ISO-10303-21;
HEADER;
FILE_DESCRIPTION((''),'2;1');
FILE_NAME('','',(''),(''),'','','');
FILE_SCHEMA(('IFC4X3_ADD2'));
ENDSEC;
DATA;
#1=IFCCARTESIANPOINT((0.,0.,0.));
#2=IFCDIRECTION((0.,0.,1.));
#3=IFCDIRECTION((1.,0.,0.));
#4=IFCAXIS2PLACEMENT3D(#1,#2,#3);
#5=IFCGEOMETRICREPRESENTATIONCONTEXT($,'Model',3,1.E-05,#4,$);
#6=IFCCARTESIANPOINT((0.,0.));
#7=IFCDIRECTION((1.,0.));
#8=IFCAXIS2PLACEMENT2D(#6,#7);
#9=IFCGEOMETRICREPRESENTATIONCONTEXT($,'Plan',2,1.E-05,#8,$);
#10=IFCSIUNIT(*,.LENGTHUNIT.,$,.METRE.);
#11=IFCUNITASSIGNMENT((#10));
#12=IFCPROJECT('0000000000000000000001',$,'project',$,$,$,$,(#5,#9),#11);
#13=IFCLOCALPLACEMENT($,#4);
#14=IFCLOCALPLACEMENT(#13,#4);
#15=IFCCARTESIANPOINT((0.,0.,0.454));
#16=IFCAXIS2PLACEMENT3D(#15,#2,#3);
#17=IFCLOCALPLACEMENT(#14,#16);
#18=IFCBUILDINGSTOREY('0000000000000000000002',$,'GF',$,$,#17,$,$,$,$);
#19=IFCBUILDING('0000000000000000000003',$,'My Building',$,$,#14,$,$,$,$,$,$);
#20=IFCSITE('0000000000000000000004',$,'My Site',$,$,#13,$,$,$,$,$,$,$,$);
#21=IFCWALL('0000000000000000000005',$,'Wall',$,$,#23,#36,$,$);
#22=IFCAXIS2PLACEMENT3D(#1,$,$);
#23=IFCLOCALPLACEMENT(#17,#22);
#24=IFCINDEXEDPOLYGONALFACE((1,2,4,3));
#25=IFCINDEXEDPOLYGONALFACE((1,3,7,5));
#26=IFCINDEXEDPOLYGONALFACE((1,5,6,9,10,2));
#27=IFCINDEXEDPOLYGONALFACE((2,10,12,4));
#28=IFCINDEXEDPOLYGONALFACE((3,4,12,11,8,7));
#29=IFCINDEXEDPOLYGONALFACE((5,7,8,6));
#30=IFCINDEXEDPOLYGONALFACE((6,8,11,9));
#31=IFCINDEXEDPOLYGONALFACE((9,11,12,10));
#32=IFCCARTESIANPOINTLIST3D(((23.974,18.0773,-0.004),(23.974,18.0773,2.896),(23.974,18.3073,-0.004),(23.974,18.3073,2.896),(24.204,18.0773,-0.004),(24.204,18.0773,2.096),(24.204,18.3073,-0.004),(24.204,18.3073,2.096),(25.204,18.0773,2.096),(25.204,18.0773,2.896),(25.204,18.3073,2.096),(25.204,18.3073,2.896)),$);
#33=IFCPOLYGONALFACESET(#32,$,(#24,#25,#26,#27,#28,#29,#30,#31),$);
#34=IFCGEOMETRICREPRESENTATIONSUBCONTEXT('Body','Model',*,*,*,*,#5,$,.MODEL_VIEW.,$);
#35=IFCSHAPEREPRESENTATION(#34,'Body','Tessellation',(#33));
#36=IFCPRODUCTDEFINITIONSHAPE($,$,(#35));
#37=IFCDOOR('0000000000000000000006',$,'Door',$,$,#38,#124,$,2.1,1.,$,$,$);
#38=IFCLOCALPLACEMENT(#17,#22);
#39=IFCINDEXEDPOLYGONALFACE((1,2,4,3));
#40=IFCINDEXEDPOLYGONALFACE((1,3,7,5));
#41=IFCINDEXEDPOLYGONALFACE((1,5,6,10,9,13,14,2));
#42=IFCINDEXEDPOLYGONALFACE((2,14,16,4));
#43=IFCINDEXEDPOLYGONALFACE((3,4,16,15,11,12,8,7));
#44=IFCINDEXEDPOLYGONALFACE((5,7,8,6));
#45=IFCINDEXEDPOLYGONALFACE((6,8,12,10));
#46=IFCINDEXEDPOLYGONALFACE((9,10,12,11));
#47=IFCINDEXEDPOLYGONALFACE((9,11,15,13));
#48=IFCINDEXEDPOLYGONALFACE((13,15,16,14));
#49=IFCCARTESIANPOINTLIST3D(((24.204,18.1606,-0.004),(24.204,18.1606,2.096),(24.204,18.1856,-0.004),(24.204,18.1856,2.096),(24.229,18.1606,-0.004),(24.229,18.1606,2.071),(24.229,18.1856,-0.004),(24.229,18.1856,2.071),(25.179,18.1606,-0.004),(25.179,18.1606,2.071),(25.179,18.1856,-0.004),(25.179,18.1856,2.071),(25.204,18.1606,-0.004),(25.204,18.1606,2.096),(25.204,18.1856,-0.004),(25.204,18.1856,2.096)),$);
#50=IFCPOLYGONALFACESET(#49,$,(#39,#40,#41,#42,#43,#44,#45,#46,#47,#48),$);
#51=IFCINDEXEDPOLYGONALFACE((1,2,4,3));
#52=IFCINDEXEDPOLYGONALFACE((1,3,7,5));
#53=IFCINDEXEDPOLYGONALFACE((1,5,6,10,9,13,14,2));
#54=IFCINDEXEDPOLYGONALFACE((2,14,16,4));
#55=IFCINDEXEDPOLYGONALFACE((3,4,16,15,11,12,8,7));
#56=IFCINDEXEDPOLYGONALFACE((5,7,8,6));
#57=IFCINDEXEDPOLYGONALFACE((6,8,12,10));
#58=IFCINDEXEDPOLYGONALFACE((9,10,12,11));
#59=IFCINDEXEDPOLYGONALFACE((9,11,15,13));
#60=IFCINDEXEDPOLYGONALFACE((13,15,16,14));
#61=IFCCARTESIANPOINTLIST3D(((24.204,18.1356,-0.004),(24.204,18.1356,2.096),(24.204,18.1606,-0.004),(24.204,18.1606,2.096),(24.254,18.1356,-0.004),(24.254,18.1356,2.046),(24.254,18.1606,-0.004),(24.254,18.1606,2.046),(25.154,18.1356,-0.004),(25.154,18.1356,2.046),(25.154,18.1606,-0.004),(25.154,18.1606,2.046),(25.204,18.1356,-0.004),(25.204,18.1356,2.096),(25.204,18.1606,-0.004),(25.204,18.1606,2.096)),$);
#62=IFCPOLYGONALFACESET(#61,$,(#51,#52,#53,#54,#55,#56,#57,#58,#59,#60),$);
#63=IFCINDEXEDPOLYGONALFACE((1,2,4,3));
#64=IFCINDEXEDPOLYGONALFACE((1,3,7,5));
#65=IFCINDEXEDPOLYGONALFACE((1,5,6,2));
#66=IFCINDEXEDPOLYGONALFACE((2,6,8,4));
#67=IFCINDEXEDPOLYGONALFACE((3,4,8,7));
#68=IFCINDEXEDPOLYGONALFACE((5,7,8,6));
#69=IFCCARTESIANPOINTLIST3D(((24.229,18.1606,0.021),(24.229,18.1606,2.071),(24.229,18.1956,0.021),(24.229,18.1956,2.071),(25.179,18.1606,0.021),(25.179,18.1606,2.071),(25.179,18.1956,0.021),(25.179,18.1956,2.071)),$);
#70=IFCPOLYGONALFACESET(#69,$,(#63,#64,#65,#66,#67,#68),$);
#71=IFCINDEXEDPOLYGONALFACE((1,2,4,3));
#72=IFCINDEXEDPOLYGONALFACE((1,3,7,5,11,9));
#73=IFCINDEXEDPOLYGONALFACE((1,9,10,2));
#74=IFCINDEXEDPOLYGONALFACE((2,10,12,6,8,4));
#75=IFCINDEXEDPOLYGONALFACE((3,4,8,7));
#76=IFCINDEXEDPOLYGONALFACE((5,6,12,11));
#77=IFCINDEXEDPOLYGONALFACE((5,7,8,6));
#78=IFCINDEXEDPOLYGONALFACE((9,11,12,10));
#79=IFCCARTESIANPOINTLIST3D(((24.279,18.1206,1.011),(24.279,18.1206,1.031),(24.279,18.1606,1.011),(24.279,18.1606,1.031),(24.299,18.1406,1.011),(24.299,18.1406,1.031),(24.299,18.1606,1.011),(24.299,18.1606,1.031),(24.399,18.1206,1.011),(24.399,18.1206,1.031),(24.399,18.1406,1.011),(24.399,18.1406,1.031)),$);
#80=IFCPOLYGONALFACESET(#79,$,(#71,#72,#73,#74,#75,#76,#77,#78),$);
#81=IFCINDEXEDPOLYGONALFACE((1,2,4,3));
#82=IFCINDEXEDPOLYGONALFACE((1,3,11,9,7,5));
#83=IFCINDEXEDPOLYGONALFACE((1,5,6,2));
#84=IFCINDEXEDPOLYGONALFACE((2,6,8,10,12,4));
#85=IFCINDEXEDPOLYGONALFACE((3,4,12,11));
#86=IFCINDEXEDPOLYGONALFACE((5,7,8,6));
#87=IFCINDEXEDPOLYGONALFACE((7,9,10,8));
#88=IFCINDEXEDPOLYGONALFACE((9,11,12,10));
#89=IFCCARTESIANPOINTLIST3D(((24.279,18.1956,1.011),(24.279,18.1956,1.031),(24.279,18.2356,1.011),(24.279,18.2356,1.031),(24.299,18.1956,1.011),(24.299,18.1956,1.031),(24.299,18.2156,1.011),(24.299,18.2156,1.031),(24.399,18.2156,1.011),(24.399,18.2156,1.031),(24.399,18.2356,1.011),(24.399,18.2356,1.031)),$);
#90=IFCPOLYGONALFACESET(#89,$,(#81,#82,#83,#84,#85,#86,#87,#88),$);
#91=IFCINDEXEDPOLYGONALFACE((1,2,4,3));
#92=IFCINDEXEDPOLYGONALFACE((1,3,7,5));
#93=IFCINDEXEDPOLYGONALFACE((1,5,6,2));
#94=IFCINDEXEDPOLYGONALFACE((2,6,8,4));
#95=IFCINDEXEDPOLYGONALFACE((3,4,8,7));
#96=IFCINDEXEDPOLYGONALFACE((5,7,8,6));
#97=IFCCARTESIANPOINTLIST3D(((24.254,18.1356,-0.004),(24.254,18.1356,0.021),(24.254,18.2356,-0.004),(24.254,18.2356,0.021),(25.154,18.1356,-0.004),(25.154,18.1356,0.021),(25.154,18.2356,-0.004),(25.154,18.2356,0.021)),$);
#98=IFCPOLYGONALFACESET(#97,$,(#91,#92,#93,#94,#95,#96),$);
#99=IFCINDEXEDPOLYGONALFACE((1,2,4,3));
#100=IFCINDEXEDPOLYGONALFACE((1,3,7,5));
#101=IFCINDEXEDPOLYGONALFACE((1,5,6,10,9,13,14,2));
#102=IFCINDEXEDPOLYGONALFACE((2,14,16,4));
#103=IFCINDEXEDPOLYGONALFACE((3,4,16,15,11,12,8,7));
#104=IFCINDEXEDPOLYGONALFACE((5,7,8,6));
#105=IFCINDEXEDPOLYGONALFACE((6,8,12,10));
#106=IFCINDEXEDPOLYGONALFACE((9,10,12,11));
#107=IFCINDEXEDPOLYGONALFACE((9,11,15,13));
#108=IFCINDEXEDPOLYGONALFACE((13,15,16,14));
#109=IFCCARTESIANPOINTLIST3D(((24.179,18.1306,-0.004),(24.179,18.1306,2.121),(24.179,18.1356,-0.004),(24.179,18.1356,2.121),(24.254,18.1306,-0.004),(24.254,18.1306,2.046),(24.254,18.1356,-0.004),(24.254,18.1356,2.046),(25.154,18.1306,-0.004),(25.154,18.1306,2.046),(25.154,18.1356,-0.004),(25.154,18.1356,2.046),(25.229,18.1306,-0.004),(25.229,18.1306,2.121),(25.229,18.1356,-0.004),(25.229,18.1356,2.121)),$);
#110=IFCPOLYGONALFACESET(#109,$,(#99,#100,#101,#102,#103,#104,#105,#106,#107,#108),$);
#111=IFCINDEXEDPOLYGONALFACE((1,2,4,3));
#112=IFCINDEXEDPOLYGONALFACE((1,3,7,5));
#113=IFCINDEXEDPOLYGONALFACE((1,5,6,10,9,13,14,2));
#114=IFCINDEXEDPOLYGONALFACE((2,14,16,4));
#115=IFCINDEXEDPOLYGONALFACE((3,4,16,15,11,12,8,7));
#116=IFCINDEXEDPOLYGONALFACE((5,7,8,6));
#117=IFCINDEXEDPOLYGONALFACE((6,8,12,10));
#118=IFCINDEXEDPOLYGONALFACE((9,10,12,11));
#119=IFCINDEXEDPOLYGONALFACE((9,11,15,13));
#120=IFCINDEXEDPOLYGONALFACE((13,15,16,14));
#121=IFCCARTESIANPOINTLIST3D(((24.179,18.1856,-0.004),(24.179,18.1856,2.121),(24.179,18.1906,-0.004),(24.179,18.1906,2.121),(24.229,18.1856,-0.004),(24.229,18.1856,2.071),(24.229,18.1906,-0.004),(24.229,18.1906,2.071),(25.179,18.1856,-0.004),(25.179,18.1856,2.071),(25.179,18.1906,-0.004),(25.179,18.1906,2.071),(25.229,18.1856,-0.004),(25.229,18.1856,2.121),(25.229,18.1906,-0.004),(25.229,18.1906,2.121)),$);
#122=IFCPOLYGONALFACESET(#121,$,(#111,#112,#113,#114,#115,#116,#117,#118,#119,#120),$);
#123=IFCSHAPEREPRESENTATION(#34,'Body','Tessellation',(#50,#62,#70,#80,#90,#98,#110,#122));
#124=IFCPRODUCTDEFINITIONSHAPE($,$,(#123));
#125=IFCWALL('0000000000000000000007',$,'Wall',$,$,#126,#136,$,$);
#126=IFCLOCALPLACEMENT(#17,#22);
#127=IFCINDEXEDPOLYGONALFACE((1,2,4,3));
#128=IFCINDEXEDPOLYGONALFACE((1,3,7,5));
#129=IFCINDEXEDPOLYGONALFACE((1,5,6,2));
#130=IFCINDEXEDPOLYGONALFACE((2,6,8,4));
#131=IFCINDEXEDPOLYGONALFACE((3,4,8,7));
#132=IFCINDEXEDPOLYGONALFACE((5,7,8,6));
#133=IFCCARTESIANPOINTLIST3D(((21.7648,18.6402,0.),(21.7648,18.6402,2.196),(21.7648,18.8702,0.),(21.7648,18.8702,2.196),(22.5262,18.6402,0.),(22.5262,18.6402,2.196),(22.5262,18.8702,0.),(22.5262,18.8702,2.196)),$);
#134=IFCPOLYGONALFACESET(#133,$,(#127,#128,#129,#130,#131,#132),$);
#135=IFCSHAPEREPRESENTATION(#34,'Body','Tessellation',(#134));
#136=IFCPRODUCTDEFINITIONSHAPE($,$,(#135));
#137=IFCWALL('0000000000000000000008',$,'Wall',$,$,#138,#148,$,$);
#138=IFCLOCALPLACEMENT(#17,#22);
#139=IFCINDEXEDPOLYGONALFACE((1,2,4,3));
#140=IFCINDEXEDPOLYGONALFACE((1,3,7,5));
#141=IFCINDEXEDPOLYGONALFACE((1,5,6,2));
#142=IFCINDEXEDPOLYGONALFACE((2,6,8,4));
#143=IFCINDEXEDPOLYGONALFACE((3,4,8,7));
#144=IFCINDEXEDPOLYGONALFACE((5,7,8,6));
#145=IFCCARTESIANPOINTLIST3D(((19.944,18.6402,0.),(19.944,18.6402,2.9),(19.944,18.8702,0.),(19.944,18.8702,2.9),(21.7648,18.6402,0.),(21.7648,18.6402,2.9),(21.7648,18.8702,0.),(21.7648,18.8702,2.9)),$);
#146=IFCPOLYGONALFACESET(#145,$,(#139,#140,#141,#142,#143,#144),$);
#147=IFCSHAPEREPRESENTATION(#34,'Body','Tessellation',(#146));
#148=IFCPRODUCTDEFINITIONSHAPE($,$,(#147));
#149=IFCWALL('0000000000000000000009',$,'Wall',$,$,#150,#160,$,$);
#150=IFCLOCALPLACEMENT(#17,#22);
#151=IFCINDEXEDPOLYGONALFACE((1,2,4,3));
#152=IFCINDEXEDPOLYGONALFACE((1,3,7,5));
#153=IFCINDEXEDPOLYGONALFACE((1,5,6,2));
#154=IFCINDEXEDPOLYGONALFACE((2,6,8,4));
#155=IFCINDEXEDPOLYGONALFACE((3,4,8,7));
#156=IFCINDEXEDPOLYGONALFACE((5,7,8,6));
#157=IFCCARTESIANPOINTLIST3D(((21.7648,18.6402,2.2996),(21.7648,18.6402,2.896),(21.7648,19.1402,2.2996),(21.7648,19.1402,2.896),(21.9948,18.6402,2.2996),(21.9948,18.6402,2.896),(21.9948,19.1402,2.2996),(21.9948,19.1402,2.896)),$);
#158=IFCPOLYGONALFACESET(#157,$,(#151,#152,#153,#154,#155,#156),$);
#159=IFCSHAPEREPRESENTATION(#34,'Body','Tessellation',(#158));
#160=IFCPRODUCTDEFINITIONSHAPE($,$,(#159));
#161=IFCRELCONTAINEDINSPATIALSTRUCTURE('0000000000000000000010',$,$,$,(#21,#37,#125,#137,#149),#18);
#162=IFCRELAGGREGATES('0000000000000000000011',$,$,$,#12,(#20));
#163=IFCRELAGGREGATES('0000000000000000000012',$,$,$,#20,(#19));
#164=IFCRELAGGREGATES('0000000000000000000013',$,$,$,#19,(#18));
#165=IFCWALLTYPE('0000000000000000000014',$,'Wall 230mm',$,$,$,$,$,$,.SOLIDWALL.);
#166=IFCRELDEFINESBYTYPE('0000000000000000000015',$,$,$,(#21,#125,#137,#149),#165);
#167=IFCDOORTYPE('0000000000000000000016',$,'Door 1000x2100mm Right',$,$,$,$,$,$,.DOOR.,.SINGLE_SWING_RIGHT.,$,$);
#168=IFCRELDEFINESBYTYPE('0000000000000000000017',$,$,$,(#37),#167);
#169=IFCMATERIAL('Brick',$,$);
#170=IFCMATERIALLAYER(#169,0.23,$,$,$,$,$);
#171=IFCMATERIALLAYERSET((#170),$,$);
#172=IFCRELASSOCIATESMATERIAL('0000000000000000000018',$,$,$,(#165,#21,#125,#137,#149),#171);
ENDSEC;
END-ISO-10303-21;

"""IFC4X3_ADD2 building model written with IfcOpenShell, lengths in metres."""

from ifc_helpers import new_model, entity, si_unit, frame, origin_with_axes, origin_2d_with_axis, place, context, subcontext, project, spatial, line, indexed_curve, outline, extrude, clip, halfspace, shape, source, transform, mapped, material, layer, layer_set, layer_usage, type_object, type_shapes, element, fill, save


model = new_model("IFC4X3_ADD2")

# Units and contexts
model_context = context("Model", 3, precision=1e-05, world=origin_with_axes())
plan_context = context("Plan", 2, precision=1e-05, world=origin_2d_with_axis())
body_context_1 = subcontext(model_context, "Body", "Model", "MODEL_VIEW")
body_context_2 = subcontext(plan_context, "Body", "Plan", "PLAN_VIEW")
ifc_project = project(units=[si_unit("LENGTHUNIT", "METRE")], contexts=[model_context, plan_context])

# Site, building, storey
site_placement = place(None, origin_with_axes())
site = spatial("IfcSite", under=ifc_project, at=site_placement, Name="My Site")
building_placement = place(site_placement, origin_with_axes())
building = spatial("IfcBuilding", under=site, at=building_placement, Name="My Building")
storey_placement = place(building_placement, frame((0.0, 0.0, 0.454), z_axis=(0.0, 0.0, 1.0), x_axis=(1.0, 0.0, 0.0)))
storey = spatial("IfcBuildingStorey", under=building, at=storey_placement, Name="GF")

# Shared definitions
ifc_material_1 = material(Name="Brick")

# Shared definitions
ifc_layer_1 = layer(ifc_material_1, 0.23)
ifc_layer_set_1 = layer_set([ifc_layer_1])
wall_type_1 = type_object("IfcWallType", Name="Wall 230mm", PredefinedType="SOLIDWALL", material=ifc_layer_set_1)

# Shared definitions
shared_shape_1 = source(origin_with_axes(), body_context_1, "Body", "SweptSolid", [
    extrude(outline(indexed_curve([(0.0, 0.0), (1.0, 0.0), (1.0, 2.1), (0.0, 2.1)], segments=[line(1, 2, 3, 4, 1)])), frame((0.0, -0.6, 0.0), z_axis=(0.0, -1.0, 0.0), x_axis=(1.0, 0.0, 0.0)), (0.0, 0.0, -1.0), 1.2),
])
door_type_1 = type_object("IfcDoorType", Name="Door 1000x2100mm Right", OperationType="SINGLE_SWING_RIGHT", PredefinedType="DOOR")
shared_shape_2 = source(origin_with_axes(), body_context_1, "Body", "SweptSolid", [
    extrude(outline(indexed_curve([(0.0, 0.0), (0.0, 2.1), (1.0, 2.1), (1.0, 0.0), (0.975, 0.0), (0.975, 2.075), (0.025, 2.075), (0.025, 0.0)], segments=[line(1, 2, 3, 4, 5, 6, 7, 8, 1)])), frame((0.0, 0.025, 0.0), z_axis=(0.0, -1.0, 0.0), x_axis=(1.0, 0.0, 0.0)), (0.0, 0.0, -1.0), 0.025),
    extrude(outline(indexed_curve([(0.0, 0.0), (0.0, 2.1), (1.0, 2.1), (1.0, 0.0), (0.95, 0.0), (0.95, 2.05), (0.05, 2.05), (0.05, 0.0)], segments=[line(1, 2, 3, 4, 5, 6, 7, 8, 1)])), frame((0.0, 0.0, 0.0), z_axis=(0.0, -1.0, 0.0), x_axis=(1.0, 0.0, 0.0)), (0.0, 0.0, -1.0), 0.025),
    extrude(outline(indexed_curve([(0.0, 0.0), (0.95, 0.0), (0.95, 0.035), (0.0, 0.035)], segments=[line(1, 2, 3, 4, 1)])), frame((0.025, 0.025, 0.025), z_axis=(0.0, 0.0, 1.0), x_axis=(1.0, 0.0, 0.0)), (0.0, 0.0, 1.0), 2.05),
    extrude(outline(indexed_curve([(0.0, 0.0), (0.0, -0.04), (0.12, -0.04), (0.12, -0.02), (0.02, -0.02), (0.02, 0.0)], segments=[line(1, 2, 3, 4, 5, 6, 1)])), frame((0.075, 0.025, 1.015), z_axis=(0.0, 0.0, 1.0), x_axis=(1.0, 0.0, 0.0)), (0.0, 0.0, 1.0), 0.02),
    extrude(outline(indexed_curve([(0.0, 0.0), (0.0, 0.04), (0.12, 0.04), (0.12, 0.02), (0.02, 0.02), (0.02, 0.0)], segments=[line(1, 2, 3, 4, 5, 6, 1)])), frame((0.075, 0.06, 1.015), z_axis=(0.0, 0.0, 1.0), x_axis=(1.0, 0.0, 0.0)), (0.0, 0.0, 1.0), 0.02),
    extrude(outline(indexed_curve([(0.0, 0.0), (0.9, 0.0), (0.9, 0.1), (0.0, 0.1)], segments=[line(1, 2, 3, 4, 1)])), frame((0.05, 0.0, 0.0), z_axis=(0.0, 0.0, 1.0), x_axis=(1.0, 0.0, 0.0)), (0.0, 0.0, 1.0), 0.025),
    extrude(outline(indexed_curve([(0.0, 0.0), (0.0, 2.125), (1.05, 2.125), (1.05, 0.0), (0.975, 0.0), (0.975, 2.05), (0.075, 2.05), (0.075, 0.0)], segments=[line(1, 2, 3, 4, 5, 6, 7, 8, 1)])), frame((-0.025, -0.005, 0.0), z_axis=(0.0, -1.0, 0.0), x_axis=(1.0, 0.0, 0.0)), (0.0, 0.0, -1.0), 0.005),
    extrude(outline(indexed_curve([(0.0, 0.0), (0.0, 2.125), (1.05, 2.125), (1.05, 0.0), (1.0, 0.0), (1.0, 2.075), (0.05, 2.075), (0.05, 0.0)], segments=[line(1, 2, 3, 4, 5, 6, 7, 8, 1)])), frame((-0.025, 0.05, 0.0), z_axis=(0.0, -1.0, 0.0), x_axis=(1.0, 0.0, 0.0)), (0.0, 0.0, -1.0), 0.005),
])
shared_shape_3 = source(origin_with_axes(), body_context_2, "Body", "Curve2D", [
    entity("IfcIndexedPolyCurve", entity("IfcCartesianPointList2D", [[0.0, 0.0], [0.0, 0.05], [0.025, 0.05], [0.025, 0.025], [0.05, 0.025], [0.05, 0.0]]), [entity("IfcLineIndex", [1, 2, 3, 4, 5, 6, 1])]),
    entity("IfcIndexedPolyCurve", entity("IfcCartesianPointList2D", [[1.0, 0.0], [1.0, 0.05], [0.975, 0.05], [0.975, 0.025], [0.95, 0.025], [0.95, 0.0]]), [entity("IfcLineIndex", [1, 2, 3, 4, 5, 6, 1])]),
    entity("IfcTrimmedCurve", entity("IfcEllipse", entity("IfcAxis2Placement2D", entity("IfcCartesianPoint", [0.94, 0.05]), entity("IfcDirection", [1.0, 0.0])), 0.915, 0.95), [entity("IfcCartesianPoint", [0.94, 1.0])], [entity("IfcCartesianPoint", [0.025, 0.05])], True, "CARTESIAN"),
    entity("IfcIndexedPolyCurve", entity("IfcCartesianPointList2D", [[0.975, 0.05], [0.94, 0.05], [0.94, 1.0], [0.975, 1.0]]), [entity("IfcLineIndex", [1, 2, 3, 4, 1])]),
])
type_shapes(door_type_1, [shared_shape_2, shared_shape_3])

# Wall, opening, door
ifc_layer_usage_1 = layer_usage(ifc_layer_set_1, "AXIS2", "POSITIVE", 0.0)
wall_1_placement = place(storey_placement, frame((25.204, 18.3073, -0.004), z_axis=(0.0, 0.0, 1.0), x_axis=(-1.0, 0.0, 0.0)))
wall_1 = element("IfcWall", 1, at=wall_1_placement, inside=storey, type_object=wall_type_1, material=ifc_layer_usage_1, Name="Wall", context=body_context_1, shape_type="SweptSolid", body=[
    extrude(outline(indexed_curve([(0.0, 0.0), (0.0, 0.23), (1.23, 0.23), (1.23, 0.0), (0.0, 0.0)], self_intersect=False)), origin_with_axes(), (0.0, 0.0, 1.0), 2.9),
])
opening_1_placement = place(wall_1_placement, frame((0.0, 0.0, 0.0), z_axis=(0.0, 0.0, 1.0), x_axis=(1.0, 0.0, 0.0)))
opening_1 = element("IfcOpeningElement", 2, at=opening_1_placement, cuts=wall_1, PredefinedType="OPENING", context=body_context_1, shape_type="MappedRepresentation", body=[
    mapped(shared_shape_1, transform((0.0, 0.0, 0.0), x_axis=(1.0, 0.0, 0.0), y_axis=(0.0, 1.0, 0.0), z_axis=(0.0, 0.0, 1.0), scale=1.0)),
])
door_1_placement = place(opening_1_placement, frame((1.0, 0.1717, 0.0), z_axis=(0.0, 0.0, 1.0), x_axis=(-1.0, 0.0, 0.0)))
door_1 = element("IfcDoor", 3, at=door_1_placement, inside=storey, type_object=door_type_1, Name="Door", OverallHeight=2.1, OverallWidth=1.0, shapes=[
    shape(body_context_1, "Body", "MappedRepresentation", [mapped(shared_shape_2, transform((0.0, 0.0, 0.0), x_axis=(1.0, 0.0, 0.0), y_axis=(0.0, 1.0, 0.0), z_axis=(0.0, 0.0, 1.0), scale=1.0))]),
    shape(body_context_2, "Body", "MappedRepresentation", [mapped(shared_shape_3, transform((0.0, 0.0, 0.0), x_axis=(1.0, 0.0, 0.0), y_axis=(0.0, 1.0, 0.0), z_axis=(0.0, 0.0, 1.0), scale=1.0))]),
])
fill(opening_1, door_1)

# Walls
ifc_layer_usage_2 = layer_usage(ifc_layer_set_1, "AXIS2", "POSITIVE", 0.0)
wall_2_placement = place(storey_placement, frame((21.7648, 18.6402, 0.0), z_axis=(0.0, 0.0, 1.0), x_axis=(1.0, -0.000001, 0.0)))
element("IfcWall", 4, at=wall_2_placement, inside=storey, type_object=wall_type_1, material=ifc_layer_usage_2, Name="Wall", context=body_context_1, shape_type="Clipping", body=[
    clip(extrude(outline(indexed_curve([(0.0, 0.0), (0.0, 0.23), (0.7614, 0.23), (0.7614, 0.0), (0.0, 0.0)], self_intersect=False)), origin_with_axes(), (0.0, 0.0, 1.0), 2.65), halfspace(frame((0.0, 0.0, 2.196), z_axis=(0.0, 0.0, 1.0), x_axis=(-1.0, 0.0, 0.0)), False)),
])
ifc_layer_usage_3 = layer_usage(ifc_layer_set_1, "AXIS2", "POSITIVE", 0.0)
wall_3_placement = place(storey_placement, frame((19.944, 18.6402, 0.0), z_axis=(0.0, 0.0, 1.0), x_axis=(1.0, -0.000001, 0.0)))
element("IfcWall", 5, at=wall_3_placement, inside=storey, type_object=wall_type_1, material=ifc_layer_usage_3, Name="Wall", context=body_context_1, shape_type="SweptSolid", body=[
    extrude(outline(indexed_curve([(0.0, 0.0), (0.0, 0.23), (1.8208, 0.23), (1.8208, 0.0), (0.0, 0.0)], self_intersect=False)), origin_with_axes(), (0.0, 0.0, 1.0), 2.9),
])
ifc_layer_usage_4 = layer_usage(ifc_layer_set_1, "AXIS2", "POSITIVE", 0.0)
wall_4_placement = place(storey_placement, frame((21.9948, 18.6402, 2.2996), z_axis=(0.0, 0.0, 1.0), x_axis=(0.000001, 1.0, 0.0)))
element("IfcWall", 6, at=wall_4_placement, inside=storey, type_object=wall_type_1, material=ifc_layer_usage_4, Name="Wall", context=body_context_1, shape_type="Clipping", body=[
    clip(extrude(outline(indexed_curve([(0.0, 0.0), (0.0, 0.23), (0.5, 0.23), (0.5, 0.0), (0.0, 0.0)], self_intersect=False)), origin_with_axes(), (0.0, 0.0, 1.0), 3.35), halfspace(frame((0.0, 0.0, 0.5964), z_axis=(0.0, 0.0, 1.0), x_axis=(-1.0, 0.0, 0.0)), False)),
])

save(model, "model.ifc")
